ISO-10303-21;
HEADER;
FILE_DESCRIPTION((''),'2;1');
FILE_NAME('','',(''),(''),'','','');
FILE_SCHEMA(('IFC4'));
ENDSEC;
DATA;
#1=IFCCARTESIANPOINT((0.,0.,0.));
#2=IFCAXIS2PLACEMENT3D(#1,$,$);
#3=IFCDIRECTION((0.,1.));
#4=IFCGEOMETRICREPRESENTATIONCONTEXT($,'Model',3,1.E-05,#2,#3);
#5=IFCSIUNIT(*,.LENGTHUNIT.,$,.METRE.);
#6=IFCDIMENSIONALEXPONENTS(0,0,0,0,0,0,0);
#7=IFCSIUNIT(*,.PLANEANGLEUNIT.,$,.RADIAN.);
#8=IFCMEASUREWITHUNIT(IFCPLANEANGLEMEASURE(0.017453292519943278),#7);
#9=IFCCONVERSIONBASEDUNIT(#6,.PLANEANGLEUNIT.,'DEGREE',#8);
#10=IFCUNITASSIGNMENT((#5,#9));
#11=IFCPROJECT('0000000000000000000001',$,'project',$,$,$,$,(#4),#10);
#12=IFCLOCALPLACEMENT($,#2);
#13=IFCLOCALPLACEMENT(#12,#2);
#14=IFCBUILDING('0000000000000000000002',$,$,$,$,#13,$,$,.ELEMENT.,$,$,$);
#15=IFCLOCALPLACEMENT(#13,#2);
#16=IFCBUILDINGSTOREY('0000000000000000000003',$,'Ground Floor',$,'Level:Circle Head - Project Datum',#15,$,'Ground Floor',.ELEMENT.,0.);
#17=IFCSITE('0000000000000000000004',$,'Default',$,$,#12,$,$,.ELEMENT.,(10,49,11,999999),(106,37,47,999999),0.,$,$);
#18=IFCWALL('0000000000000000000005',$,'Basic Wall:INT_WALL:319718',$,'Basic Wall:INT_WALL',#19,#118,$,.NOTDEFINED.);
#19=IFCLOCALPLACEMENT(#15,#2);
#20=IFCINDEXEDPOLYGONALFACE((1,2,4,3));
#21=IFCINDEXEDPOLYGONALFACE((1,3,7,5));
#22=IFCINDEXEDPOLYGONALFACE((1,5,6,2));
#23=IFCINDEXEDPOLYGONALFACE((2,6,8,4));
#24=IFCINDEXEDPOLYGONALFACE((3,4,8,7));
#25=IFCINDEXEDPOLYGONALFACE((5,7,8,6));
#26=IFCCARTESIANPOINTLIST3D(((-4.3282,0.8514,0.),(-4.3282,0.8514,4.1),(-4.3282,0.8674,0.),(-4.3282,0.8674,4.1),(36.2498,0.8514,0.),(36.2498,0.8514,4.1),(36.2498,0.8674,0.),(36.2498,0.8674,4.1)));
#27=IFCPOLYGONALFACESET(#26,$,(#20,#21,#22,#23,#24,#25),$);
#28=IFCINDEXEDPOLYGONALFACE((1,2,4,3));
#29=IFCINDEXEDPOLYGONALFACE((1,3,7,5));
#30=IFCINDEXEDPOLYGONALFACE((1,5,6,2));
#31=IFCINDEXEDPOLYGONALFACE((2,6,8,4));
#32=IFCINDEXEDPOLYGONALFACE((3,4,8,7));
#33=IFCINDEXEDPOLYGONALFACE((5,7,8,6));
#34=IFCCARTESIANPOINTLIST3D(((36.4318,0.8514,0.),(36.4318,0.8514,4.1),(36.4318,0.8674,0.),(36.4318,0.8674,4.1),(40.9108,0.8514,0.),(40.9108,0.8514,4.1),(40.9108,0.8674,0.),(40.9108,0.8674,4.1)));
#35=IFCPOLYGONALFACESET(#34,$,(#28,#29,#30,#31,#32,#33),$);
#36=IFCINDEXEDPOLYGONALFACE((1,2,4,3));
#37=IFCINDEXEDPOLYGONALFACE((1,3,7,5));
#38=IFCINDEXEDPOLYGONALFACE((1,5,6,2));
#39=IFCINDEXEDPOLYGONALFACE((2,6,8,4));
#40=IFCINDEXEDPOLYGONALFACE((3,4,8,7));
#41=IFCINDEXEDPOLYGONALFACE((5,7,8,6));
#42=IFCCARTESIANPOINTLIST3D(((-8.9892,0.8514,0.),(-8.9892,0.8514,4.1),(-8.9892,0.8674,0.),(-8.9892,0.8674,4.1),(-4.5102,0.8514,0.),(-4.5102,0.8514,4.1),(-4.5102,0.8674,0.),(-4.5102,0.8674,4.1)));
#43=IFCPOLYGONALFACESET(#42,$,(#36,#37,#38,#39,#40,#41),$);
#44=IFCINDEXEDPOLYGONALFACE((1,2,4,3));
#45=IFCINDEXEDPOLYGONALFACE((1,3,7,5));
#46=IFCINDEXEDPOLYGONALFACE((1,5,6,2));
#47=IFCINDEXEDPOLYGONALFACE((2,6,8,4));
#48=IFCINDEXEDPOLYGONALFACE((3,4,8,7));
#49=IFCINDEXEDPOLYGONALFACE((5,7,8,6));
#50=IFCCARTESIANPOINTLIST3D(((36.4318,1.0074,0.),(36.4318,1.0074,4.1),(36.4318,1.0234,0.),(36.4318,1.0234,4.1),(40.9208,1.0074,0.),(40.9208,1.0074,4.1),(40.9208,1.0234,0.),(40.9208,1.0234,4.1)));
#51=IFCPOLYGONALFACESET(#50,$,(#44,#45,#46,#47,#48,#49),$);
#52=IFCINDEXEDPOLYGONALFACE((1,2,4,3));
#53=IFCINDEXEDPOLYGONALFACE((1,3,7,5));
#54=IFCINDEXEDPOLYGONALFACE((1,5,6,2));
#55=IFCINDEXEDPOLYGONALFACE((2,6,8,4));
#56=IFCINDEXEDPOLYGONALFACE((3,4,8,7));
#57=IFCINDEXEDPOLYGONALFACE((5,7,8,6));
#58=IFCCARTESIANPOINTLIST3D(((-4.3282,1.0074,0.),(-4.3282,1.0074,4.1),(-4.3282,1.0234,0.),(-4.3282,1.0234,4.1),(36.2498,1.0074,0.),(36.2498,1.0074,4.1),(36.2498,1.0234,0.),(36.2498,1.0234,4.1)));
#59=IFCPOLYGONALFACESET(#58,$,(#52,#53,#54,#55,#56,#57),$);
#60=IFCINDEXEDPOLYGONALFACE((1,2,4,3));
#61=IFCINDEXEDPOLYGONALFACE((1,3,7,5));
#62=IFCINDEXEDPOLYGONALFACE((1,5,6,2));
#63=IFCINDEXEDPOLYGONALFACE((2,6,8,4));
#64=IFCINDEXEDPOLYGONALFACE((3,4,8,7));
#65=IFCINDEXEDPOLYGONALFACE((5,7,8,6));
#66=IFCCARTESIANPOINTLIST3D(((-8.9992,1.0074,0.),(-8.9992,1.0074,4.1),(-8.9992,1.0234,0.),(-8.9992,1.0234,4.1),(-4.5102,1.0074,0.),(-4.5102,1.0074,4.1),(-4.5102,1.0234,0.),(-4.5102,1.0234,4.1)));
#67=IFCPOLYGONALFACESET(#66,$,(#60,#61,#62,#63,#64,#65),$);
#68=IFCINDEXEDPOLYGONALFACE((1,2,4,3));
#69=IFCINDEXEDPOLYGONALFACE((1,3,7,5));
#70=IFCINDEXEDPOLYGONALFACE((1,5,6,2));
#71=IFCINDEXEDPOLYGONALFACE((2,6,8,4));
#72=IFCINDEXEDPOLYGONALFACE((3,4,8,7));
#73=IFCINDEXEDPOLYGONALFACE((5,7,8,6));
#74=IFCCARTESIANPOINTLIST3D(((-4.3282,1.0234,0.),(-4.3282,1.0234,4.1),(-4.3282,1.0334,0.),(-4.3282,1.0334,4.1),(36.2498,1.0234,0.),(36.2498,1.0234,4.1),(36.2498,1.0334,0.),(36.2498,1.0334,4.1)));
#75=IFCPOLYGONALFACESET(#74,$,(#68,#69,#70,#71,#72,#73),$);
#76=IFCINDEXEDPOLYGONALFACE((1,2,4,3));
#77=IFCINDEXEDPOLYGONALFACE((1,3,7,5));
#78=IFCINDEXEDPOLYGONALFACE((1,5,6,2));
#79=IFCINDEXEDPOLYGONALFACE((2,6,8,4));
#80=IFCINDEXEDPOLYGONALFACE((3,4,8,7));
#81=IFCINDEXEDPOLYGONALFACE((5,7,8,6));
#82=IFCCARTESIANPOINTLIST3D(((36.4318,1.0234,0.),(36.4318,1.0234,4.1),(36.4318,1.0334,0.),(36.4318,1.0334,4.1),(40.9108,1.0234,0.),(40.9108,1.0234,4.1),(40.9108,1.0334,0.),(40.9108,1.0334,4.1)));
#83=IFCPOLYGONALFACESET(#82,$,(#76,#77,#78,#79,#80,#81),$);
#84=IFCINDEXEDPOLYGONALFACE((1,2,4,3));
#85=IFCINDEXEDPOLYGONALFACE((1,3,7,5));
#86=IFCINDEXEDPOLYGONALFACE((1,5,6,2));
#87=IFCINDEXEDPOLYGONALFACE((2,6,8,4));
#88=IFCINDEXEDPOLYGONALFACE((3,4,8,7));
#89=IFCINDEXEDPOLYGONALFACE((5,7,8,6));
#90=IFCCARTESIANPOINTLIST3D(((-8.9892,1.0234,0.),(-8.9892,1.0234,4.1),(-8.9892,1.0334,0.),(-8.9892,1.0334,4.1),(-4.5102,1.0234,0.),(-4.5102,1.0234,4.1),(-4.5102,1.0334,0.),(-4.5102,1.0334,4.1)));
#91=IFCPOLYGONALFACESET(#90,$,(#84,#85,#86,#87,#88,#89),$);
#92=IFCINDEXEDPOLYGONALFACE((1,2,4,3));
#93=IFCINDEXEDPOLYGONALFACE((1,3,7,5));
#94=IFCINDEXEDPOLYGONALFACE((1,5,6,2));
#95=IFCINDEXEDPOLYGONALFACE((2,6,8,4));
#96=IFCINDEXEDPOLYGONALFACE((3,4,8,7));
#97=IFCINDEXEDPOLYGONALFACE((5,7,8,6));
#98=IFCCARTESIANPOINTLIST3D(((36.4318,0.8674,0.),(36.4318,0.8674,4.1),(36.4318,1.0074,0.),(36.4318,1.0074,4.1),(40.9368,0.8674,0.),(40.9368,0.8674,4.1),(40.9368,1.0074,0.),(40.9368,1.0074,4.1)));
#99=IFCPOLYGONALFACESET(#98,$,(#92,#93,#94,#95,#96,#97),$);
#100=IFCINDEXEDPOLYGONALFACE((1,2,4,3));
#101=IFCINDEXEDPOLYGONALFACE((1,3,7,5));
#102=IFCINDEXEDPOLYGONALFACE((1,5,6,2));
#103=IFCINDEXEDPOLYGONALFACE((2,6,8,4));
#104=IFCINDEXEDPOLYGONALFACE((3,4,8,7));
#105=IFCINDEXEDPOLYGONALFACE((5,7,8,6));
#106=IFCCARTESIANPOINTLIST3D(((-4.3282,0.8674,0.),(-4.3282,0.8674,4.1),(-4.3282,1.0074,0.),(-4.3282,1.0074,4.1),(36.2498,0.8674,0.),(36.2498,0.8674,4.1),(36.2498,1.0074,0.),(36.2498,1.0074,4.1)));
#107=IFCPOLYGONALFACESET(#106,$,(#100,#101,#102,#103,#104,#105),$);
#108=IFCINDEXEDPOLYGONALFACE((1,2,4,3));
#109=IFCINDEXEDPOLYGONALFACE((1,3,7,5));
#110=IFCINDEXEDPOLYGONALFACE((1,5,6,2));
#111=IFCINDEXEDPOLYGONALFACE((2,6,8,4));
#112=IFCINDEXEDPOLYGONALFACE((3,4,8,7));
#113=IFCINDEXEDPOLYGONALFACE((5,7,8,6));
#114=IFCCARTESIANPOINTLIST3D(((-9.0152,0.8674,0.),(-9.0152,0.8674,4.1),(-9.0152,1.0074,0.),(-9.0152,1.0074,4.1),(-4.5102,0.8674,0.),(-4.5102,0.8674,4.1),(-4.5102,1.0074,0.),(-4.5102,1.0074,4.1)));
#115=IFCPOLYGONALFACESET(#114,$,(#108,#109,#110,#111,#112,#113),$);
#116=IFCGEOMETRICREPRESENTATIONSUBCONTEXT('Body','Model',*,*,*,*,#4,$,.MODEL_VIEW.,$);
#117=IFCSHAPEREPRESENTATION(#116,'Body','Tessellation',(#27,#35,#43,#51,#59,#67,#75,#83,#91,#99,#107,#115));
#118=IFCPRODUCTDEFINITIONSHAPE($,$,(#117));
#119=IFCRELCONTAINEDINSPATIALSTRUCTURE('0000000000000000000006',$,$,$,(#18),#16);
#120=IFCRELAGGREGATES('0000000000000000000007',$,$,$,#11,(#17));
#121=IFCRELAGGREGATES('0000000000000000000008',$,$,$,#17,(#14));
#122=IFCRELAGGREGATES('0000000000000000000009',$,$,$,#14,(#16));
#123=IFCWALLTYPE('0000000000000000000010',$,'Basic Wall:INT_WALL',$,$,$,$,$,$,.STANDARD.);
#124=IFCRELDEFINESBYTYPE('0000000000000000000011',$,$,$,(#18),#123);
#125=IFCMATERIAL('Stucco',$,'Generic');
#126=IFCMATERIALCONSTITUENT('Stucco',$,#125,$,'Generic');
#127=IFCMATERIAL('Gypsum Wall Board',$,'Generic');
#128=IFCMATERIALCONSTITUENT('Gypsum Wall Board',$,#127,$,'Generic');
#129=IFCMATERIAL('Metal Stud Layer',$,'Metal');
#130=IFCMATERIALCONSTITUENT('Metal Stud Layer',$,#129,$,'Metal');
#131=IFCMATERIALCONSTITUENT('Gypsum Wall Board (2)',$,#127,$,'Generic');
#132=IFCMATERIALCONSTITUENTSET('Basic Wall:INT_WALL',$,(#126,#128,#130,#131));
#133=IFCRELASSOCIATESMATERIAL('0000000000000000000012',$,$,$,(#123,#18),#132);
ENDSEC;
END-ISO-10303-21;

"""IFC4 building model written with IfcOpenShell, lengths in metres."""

from ifc_helpers import new_model, entity, si_unit, converted_unit, direction, frame, origin, place, context, subcontext, project, spatial, indexed_curve, outline, extrude, material, constituent, constituent_set, type_object, element, save


model = new_model("IFC4")

# Units and contexts
model_context = context("Model", 3, precision=1e-05, world=origin(), true_north=direction((0.0, 1.0)))
body_context = subcontext(model_context, "Body", "Model", "MODEL_VIEW")
ifc_project = project(units=[si_unit("LENGTHUNIT", "METRE"), converted_unit("PLANEANGLEUNIT", "DEGREE", entity("IfcPlaneAngleMeasure", 0.017453292519943278), si_unit("PLANEANGLEUNIT", "RADIAN"), dimensions=[0, 0, 0, 0, 0, 0, 0])], contexts=[model_context])

# Site, building, storey
site_placement = place(None, origin())
site = spatial("IfcSite", under=ifc_project, at=site_placement, Name="Default", CompositionType="ELEMENT", RefLatitude=(10, 49, 11, 999999), RefLongitude=(106, 37, 47, 999999), RefElevation=0.0)
building_placement = place(site_placement, origin())
building = spatial("IfcBuilding", under=site, at=building_placement, CompositionType="ELEMENT")
storey_placement = place(building_placement, origin())
storey = spatial("IfcBuildingStorey", under=building, at=storey_placement, Name="Ground Floor", ObjectType="Level:Circle Head - Project Datum", LongName="Ground Floor", CompositionType="ELEMENT", Elevation=0.0)

# Shared definitions
ifc_material_1 = material(Name="Stucco", Category="Generic")
ifc_material_2 = material(Name="Gypsum Wall Board", Category="Generic")
ifc_material_3 = material(Name="Metal Stud Layer", Category="Metal")

# Wall
ifc_constituent_1 = constituent(ifc_material_1, Name="Stucco", Category="Generic")
ifc_constituent_2 = constituent(ifc_material_2, Name="Gypsum Wall Board", Category="Generic")
ifc_constituent_3 = constituent(ifc_material_3, Name="Metal Stud Layer", Category="Metal")
ifc_constituent_4 = constituent(ifc_material_2, Name="Gypsum Wall Board (2)", Category="Generic")
ifc_constituent_set_1 = constituent_set(constituents=[ifc_constituent_1, ifc_constituent_2, ifc_constituent_3, ifc_constituent_4], Name="Basic Wall:INT_WALL")
wall_type_1 = type_object("IfcWallType", Name="Basic Wall:INT_WALL", PredefinedType="STANDARD", material=ifc_constituent_set_1)
wall_1_placement = place(storey_placement, frame((-8.9892, 0.9424, 0.0)))
element("IfcWall", 1, at=wall_1_placement, inside=storey, type_object=wall_type_1, material=ifc_constituent_set_1, Name="Basic Wall:INT_WALL:319718", ObjectType="Basic Wall:INT_WALL", PredefinedType="NOTDEFINED", context=body_context, shape_type="SweptSolid", body=[
    extrude(outline(indexed_curve([(-0.008, -20.289), (0.008, -20.289), (0.008, 20.289), (-0.008, 20.289), (-0.008, -20.289)], self_intersect=False)), frame((24.95, -0.083, 0.0), z_axis=(0.0, 0.0, 1.0), x_axis=(0.0, 1.0, 0.0)), (0.0, 0.0, 1.0), 4.1),
    extrude(outline(indexed_curve([(-0.008, -2.2395), (0.008, -2.2395), (0.008, 2.2395), (-0.008, 2.2395), (-0.008, -2.2395)], self_intersect=False)), frame((47.6605, -0.083, 0.0), z_axis=(0.0, 0.0, 1.0), x_axis=(0.0, 1.0, 0.0)), (0.0, 0.0, 1.0), 4.1),
    extrude(outline(indexed_curve([(-0.008, -2.2395), (0.008, -2.2395), (0.008, 2.2395), (-0.008, 2.2395), (-0.008, -2.2395)], self_intersect=False)), frame((2.2395, -0.083, 0.0), z_axis=(0.0, 0.0, 1.0), x_axis=(0.0, 1.0, 0.0)), (0.0, 0.0, 1.0), 4.1),
    extrude(outline(indexed_curve([(-2.2445, -0.008), (2.2445, -0.008), (2.2445, 0.008), (-2.2445, 0.008), (-2.2445, -0.008)], self_intersect=False)), frame((47.6655, 0.073, 0.0), z_axis=(0.0, 0.0, 1.0), x_axis=(-1.0, 0.0, 0.0)), (0.0, 0.0, 1.0), 4.1),
    extrude(outline(indexed_curve([(-20.289, -0.008), (20.289, -0.008), (20.289, 0.008), (-20.289, 0.008), (-20.289, -0.008)], self_intersect=False)), frame((24.95, 0.073, 0.0)), (0.0, 0.0, 1.0), 4.1),
    extrude(outline(indexed_curve([(-2.2445, -0.008), (2.2445, -0.008), (2.2445, 0.008), (-2.2445, 0.008), (-2.2445, -0.008)], self_intersect=False)), frame((2.2345, 0.073, 0.0)), (0.0, 0.0, 1.0), 4.1),
    extrude(outline(indexed_curve([(-0.005, -20.289), (0.005, -20.289), (0.005, 20.289), (-0.005, 20.289), (-0.005, -20.289)], self_intersect=False)), frame((24.95, 0.086, 0.0), z_axis=(0.0, 0.0, 1.0), x_axis=(0.0, -1.0, 0.0)), (0.0, 0.0, 1.0), 4.1),
    extrude(outline(indexed_curve([(-0.005, -2.2395), (0.005, -2.2395), (0.005, 2.2395), (-0.005, 2.2395), (-0.005, -2.2395)], self_intersect=False)), frame((47.6605, 0.086, 0.0), z_axis=(0.0, 0.0, 1.0), x_axis=(0.0, -1.0, 0.0)), (0.0, 0.0, 1.0), 4.1),
    extrude(outline(indexed_curve([(-0.005, -2.2395), (0.005, -2.2395), (0.005, 2.2395), (-0.005, 2.2395), (-0.005, -2.2395)], self_intersect=False)), frame((2.2395, 0.086, 0.0), z_axis=(0.0, 0.0, 1.0), x_axis=(0.0, -1.0, 0.0)), (0.0, 0.0, 1.0), 4.1),
    extrude(outline(indexed_curve([(-2.2525, -0.07), (2.2525, -0.07), (2.2525, 0.07), (-2.2525, 0.07), (-2.2525, -0.07)], self_intersect=False)), frame((47.6735, -0.005, 0.0), z_axis=(0.0, 0.0, 1.0), x_axis=(-1.0, 0.0, 0.0)), (0.0, 0.0, 1.0), 4.1),
    extrude(outline(indexed_curve([(-20.289, -0.07), (20.289, -0.07), (20.289, 0.07), (-20.289, 0.07), (-20.289, -0.07)], self_intersect=False)), frame((24.95, -0.005, 0.0)), (0.0, 0.0, 1.0), 4.1),
    extrude(outline(indexed_curve([(-2.2525, -0.07), (2.2525, -0.07), (2.2525, 0.07), (-2.2525, 0.07), (-2.2525, -0.07)], self_intersect=False)), frame((2.2265, -0.005, 0.0)), (0.0, 0.0, 1.0), 4.1),
])

save(model, "model.ifc")
